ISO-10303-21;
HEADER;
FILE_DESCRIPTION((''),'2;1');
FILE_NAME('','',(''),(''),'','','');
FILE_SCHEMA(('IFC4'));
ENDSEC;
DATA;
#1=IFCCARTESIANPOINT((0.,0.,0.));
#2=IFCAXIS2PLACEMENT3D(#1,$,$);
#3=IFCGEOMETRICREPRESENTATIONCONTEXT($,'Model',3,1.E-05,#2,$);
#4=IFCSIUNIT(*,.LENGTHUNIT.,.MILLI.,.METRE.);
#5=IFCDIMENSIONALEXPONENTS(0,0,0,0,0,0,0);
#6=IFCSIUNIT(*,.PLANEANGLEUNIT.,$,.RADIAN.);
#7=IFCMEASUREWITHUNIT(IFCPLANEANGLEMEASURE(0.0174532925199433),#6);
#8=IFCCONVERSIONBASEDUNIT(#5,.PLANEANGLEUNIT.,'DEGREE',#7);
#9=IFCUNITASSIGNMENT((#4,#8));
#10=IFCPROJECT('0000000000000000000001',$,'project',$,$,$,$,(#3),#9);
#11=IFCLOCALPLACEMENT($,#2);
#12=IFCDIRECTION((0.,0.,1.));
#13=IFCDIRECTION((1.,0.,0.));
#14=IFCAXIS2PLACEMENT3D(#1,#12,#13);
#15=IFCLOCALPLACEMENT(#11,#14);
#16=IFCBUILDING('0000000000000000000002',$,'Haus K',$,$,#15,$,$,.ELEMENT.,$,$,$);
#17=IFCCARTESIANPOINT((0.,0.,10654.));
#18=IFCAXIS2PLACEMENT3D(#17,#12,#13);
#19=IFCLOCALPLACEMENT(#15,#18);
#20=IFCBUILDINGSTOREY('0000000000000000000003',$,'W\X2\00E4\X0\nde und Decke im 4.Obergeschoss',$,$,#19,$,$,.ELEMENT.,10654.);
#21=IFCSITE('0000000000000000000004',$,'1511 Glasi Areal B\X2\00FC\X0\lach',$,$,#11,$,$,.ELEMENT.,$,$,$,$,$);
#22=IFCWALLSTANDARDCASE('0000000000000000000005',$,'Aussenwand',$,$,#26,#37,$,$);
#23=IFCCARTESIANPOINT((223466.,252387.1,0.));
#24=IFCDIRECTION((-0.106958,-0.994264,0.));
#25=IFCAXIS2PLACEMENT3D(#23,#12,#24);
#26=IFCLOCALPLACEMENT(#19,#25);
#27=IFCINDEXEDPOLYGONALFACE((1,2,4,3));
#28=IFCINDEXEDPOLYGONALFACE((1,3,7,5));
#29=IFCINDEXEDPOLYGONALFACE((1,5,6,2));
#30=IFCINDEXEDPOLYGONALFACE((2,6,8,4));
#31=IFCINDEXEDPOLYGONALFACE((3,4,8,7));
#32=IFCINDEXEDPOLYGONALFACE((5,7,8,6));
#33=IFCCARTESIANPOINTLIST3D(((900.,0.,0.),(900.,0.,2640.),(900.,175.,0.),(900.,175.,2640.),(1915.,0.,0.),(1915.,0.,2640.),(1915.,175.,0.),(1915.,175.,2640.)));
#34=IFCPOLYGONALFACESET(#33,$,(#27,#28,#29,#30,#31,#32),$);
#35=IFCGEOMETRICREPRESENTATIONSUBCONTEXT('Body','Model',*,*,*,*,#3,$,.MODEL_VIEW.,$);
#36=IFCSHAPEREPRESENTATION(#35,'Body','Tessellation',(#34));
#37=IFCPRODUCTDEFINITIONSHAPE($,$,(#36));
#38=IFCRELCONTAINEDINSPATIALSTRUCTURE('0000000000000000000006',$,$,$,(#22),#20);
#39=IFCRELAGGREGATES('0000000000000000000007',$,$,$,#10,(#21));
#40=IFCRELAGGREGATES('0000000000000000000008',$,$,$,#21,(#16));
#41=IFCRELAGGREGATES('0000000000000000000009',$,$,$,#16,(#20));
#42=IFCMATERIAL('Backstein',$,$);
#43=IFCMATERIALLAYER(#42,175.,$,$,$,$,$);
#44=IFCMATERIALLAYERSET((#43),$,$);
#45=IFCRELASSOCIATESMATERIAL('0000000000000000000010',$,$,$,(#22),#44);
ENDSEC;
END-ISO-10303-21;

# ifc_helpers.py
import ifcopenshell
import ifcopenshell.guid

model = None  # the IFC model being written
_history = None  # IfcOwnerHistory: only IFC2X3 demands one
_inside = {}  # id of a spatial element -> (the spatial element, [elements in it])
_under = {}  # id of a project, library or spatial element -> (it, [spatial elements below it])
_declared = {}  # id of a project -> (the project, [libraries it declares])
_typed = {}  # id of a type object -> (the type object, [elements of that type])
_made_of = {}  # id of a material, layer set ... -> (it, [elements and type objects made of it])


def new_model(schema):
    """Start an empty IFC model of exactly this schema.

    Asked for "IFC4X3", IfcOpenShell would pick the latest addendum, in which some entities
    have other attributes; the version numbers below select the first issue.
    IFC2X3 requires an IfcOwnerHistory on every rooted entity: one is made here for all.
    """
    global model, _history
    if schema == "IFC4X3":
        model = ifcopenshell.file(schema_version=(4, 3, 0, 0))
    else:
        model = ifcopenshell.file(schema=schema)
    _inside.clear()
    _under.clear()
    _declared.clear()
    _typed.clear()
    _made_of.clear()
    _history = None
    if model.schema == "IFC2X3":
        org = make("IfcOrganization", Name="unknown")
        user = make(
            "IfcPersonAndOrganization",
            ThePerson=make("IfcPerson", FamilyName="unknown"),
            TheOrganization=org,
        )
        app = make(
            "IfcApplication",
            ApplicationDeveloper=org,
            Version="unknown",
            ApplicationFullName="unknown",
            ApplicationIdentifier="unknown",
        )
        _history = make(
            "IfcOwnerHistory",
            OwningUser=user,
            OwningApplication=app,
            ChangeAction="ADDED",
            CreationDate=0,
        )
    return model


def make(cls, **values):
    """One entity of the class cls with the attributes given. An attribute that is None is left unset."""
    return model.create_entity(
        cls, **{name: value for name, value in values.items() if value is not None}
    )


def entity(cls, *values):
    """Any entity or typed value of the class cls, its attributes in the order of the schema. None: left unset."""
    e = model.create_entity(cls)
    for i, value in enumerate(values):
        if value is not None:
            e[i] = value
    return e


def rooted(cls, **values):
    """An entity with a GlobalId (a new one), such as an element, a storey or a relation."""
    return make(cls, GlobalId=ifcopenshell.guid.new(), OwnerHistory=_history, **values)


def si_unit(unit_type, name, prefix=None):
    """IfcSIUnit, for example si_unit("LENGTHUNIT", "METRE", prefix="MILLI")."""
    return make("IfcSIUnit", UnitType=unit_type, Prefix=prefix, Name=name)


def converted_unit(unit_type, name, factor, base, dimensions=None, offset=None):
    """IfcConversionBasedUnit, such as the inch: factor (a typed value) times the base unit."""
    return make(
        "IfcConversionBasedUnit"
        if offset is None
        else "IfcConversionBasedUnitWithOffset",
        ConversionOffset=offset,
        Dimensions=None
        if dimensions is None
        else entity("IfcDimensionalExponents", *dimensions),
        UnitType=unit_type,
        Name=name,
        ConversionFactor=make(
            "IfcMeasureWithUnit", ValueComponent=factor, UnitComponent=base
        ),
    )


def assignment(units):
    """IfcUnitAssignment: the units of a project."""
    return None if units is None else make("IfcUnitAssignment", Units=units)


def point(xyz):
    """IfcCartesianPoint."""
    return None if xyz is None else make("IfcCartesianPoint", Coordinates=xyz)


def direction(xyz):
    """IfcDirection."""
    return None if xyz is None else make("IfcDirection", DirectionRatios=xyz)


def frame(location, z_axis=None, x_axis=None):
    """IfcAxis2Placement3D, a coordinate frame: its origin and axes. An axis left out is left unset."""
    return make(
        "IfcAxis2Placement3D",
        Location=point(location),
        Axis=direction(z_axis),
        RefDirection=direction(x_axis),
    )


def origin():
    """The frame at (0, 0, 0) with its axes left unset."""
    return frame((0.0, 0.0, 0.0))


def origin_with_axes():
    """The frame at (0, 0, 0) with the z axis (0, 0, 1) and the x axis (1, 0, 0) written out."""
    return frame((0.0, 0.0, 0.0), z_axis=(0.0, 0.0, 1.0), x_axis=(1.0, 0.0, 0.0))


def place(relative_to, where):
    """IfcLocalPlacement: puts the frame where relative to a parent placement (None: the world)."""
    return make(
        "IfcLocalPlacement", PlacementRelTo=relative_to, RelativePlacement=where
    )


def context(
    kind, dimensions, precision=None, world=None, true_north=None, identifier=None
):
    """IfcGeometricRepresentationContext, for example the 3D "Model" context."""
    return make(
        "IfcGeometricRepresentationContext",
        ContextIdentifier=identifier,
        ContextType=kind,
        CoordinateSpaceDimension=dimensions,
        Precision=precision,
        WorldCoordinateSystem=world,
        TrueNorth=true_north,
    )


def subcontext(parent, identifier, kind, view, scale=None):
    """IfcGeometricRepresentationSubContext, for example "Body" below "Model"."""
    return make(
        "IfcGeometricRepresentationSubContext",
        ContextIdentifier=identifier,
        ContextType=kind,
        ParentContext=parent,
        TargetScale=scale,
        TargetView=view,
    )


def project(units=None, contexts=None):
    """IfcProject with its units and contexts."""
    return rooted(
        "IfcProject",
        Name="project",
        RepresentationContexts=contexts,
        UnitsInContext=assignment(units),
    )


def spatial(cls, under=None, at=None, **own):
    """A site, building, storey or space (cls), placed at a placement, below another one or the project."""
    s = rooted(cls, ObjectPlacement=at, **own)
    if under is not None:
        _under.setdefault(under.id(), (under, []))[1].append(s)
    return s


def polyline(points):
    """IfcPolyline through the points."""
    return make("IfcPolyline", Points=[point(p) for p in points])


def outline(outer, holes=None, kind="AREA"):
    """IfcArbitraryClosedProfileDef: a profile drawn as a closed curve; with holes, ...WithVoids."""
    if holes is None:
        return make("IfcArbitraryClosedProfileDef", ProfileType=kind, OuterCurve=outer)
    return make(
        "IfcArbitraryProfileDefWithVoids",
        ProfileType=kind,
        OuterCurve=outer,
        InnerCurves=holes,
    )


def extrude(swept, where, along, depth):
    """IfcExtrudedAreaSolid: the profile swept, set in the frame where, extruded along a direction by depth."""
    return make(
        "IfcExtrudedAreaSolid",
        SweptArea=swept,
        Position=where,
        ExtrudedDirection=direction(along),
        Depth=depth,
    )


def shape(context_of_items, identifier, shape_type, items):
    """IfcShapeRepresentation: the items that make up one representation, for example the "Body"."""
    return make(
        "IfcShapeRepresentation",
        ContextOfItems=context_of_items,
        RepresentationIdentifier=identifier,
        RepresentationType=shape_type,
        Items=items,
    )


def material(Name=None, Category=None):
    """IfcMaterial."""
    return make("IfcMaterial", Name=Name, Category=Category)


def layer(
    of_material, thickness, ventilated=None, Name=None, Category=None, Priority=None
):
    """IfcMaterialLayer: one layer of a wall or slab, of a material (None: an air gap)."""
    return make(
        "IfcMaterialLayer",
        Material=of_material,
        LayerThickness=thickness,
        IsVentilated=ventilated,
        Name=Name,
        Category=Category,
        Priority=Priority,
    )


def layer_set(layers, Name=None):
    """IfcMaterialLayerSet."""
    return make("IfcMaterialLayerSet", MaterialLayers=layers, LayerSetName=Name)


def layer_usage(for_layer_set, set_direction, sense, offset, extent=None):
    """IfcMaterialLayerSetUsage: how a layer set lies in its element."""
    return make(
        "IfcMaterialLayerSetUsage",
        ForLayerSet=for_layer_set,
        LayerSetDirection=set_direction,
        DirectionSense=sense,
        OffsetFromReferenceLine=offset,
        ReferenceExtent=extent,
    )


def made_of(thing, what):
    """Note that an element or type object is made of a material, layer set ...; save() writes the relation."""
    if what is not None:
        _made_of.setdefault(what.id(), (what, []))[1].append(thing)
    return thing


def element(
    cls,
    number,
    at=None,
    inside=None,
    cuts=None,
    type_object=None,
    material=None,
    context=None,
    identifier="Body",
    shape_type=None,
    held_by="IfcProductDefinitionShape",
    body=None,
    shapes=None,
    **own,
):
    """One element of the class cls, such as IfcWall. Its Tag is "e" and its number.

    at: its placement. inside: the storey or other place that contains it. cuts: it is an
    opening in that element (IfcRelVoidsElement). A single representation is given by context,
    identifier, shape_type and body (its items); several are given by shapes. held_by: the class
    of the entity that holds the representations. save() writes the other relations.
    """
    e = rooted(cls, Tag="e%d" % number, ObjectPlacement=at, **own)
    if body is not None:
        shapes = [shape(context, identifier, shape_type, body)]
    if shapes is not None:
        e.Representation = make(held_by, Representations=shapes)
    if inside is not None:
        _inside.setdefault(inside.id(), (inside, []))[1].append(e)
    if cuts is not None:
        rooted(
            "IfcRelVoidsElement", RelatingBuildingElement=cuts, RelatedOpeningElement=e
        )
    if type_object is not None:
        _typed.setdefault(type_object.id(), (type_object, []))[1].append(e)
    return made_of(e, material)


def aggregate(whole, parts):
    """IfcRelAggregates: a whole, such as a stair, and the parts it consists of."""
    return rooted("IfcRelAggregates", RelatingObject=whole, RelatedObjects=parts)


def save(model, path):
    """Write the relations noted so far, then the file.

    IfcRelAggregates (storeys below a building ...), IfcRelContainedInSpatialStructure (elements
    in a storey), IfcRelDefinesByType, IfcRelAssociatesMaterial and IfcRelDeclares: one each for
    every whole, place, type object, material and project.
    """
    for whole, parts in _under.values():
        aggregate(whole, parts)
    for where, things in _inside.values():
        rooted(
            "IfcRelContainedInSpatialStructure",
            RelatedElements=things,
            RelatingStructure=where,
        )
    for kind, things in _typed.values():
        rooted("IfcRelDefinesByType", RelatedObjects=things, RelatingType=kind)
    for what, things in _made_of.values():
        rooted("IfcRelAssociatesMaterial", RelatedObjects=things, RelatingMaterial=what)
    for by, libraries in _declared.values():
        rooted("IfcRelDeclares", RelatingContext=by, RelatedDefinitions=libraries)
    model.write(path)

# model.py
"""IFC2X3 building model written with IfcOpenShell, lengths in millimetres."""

from ifc_helpers import new_model, entity, si_unit, converted_unit, frame, origin, origin_with_axes, place, context, subcontext, project, spatial, polyline, outline, extrude, material, layer, layer_set, layer_usage, element, save


model = new_model("IFC2X3")

# Units and contexts
model_context = context("Model", 3, precision=1e-05, world=origin())
body_context = subcontext(model_context, "Body", "Model", "MODEL_VIEW")
ifc_project = project(units=[si_unit("LENGTHUNIT", "METRE", prefix="MILLI"), converted_unit("PLANEANGLEUNIT", "DEGREE", entity("IfcPlaneAngleMeasure", 0.0174532925199433), si_unit("PLANEANGLEUNIT", "RADIAN"), dimensions=[0, 0, 0, 0, 0, 0, 0])], contexts=[model_context])

# Site, building, storey
site_placement = place(None, origin())
site = spatial("IfcSite", under=ifc_project, at=site_placement, Name="1511 Glasi Areal Bülach", CompositionType="ELEMENT")
building_placement = place(site_placement, origin_with_axes())
building = spatial("IfcBuilding", under=site, at=building_placement, Name="Haus K", CompositionType="ELEMENT")
storey_placement = place(building_placement, frame((0.0, 0.0, 10654.0), z_axis=(0.0, 0.0, 1.0), x_axis=(1.0, 0.0, 0.0)))
storey = spatial("IfcBuildingStorey", under=building, at=storey_placement, Name="Wände und Decke im 4.Obergeschoss", CompositionType="ELEMENT", Elevation=10654.0)

# Wall
ifc_material_1 = material(Name="Backstein")
ifc_layer_1 = layer(ifc_material_1, 175.0)
ifc_layer_set_1 = layer_set([ifc_layer_1])
ifc_layer_usage_1 = layer_usage(ifc_layer_set_1, "AXIS2", "POSITIVE", 0.0)
wall_1_placement = place(storey_placement, frame((223466.0, 252387.1, 0.0), z_axis=(0.0, 0.0, 1.0), x_axis=(-0.106958, -0.994264, 0.0)))
element("IfcWallStandardCase", 1, at=wall_1_placement, inside=storey, material=ifc_layer_usage_1, Name="Aussenwand", context=body_context, shape_type="SweptSolid", body=[
    extrude(outline(polyline([(900.0, 0.0), (1915.0, 0.0), (1915.0, 175.0), (900.0, 175.0), (900.0, 0.0)])), origin_with_axes(), (0.0, 0.0, 1.0), 2640.0),
])

save(model, "model.ifc")
